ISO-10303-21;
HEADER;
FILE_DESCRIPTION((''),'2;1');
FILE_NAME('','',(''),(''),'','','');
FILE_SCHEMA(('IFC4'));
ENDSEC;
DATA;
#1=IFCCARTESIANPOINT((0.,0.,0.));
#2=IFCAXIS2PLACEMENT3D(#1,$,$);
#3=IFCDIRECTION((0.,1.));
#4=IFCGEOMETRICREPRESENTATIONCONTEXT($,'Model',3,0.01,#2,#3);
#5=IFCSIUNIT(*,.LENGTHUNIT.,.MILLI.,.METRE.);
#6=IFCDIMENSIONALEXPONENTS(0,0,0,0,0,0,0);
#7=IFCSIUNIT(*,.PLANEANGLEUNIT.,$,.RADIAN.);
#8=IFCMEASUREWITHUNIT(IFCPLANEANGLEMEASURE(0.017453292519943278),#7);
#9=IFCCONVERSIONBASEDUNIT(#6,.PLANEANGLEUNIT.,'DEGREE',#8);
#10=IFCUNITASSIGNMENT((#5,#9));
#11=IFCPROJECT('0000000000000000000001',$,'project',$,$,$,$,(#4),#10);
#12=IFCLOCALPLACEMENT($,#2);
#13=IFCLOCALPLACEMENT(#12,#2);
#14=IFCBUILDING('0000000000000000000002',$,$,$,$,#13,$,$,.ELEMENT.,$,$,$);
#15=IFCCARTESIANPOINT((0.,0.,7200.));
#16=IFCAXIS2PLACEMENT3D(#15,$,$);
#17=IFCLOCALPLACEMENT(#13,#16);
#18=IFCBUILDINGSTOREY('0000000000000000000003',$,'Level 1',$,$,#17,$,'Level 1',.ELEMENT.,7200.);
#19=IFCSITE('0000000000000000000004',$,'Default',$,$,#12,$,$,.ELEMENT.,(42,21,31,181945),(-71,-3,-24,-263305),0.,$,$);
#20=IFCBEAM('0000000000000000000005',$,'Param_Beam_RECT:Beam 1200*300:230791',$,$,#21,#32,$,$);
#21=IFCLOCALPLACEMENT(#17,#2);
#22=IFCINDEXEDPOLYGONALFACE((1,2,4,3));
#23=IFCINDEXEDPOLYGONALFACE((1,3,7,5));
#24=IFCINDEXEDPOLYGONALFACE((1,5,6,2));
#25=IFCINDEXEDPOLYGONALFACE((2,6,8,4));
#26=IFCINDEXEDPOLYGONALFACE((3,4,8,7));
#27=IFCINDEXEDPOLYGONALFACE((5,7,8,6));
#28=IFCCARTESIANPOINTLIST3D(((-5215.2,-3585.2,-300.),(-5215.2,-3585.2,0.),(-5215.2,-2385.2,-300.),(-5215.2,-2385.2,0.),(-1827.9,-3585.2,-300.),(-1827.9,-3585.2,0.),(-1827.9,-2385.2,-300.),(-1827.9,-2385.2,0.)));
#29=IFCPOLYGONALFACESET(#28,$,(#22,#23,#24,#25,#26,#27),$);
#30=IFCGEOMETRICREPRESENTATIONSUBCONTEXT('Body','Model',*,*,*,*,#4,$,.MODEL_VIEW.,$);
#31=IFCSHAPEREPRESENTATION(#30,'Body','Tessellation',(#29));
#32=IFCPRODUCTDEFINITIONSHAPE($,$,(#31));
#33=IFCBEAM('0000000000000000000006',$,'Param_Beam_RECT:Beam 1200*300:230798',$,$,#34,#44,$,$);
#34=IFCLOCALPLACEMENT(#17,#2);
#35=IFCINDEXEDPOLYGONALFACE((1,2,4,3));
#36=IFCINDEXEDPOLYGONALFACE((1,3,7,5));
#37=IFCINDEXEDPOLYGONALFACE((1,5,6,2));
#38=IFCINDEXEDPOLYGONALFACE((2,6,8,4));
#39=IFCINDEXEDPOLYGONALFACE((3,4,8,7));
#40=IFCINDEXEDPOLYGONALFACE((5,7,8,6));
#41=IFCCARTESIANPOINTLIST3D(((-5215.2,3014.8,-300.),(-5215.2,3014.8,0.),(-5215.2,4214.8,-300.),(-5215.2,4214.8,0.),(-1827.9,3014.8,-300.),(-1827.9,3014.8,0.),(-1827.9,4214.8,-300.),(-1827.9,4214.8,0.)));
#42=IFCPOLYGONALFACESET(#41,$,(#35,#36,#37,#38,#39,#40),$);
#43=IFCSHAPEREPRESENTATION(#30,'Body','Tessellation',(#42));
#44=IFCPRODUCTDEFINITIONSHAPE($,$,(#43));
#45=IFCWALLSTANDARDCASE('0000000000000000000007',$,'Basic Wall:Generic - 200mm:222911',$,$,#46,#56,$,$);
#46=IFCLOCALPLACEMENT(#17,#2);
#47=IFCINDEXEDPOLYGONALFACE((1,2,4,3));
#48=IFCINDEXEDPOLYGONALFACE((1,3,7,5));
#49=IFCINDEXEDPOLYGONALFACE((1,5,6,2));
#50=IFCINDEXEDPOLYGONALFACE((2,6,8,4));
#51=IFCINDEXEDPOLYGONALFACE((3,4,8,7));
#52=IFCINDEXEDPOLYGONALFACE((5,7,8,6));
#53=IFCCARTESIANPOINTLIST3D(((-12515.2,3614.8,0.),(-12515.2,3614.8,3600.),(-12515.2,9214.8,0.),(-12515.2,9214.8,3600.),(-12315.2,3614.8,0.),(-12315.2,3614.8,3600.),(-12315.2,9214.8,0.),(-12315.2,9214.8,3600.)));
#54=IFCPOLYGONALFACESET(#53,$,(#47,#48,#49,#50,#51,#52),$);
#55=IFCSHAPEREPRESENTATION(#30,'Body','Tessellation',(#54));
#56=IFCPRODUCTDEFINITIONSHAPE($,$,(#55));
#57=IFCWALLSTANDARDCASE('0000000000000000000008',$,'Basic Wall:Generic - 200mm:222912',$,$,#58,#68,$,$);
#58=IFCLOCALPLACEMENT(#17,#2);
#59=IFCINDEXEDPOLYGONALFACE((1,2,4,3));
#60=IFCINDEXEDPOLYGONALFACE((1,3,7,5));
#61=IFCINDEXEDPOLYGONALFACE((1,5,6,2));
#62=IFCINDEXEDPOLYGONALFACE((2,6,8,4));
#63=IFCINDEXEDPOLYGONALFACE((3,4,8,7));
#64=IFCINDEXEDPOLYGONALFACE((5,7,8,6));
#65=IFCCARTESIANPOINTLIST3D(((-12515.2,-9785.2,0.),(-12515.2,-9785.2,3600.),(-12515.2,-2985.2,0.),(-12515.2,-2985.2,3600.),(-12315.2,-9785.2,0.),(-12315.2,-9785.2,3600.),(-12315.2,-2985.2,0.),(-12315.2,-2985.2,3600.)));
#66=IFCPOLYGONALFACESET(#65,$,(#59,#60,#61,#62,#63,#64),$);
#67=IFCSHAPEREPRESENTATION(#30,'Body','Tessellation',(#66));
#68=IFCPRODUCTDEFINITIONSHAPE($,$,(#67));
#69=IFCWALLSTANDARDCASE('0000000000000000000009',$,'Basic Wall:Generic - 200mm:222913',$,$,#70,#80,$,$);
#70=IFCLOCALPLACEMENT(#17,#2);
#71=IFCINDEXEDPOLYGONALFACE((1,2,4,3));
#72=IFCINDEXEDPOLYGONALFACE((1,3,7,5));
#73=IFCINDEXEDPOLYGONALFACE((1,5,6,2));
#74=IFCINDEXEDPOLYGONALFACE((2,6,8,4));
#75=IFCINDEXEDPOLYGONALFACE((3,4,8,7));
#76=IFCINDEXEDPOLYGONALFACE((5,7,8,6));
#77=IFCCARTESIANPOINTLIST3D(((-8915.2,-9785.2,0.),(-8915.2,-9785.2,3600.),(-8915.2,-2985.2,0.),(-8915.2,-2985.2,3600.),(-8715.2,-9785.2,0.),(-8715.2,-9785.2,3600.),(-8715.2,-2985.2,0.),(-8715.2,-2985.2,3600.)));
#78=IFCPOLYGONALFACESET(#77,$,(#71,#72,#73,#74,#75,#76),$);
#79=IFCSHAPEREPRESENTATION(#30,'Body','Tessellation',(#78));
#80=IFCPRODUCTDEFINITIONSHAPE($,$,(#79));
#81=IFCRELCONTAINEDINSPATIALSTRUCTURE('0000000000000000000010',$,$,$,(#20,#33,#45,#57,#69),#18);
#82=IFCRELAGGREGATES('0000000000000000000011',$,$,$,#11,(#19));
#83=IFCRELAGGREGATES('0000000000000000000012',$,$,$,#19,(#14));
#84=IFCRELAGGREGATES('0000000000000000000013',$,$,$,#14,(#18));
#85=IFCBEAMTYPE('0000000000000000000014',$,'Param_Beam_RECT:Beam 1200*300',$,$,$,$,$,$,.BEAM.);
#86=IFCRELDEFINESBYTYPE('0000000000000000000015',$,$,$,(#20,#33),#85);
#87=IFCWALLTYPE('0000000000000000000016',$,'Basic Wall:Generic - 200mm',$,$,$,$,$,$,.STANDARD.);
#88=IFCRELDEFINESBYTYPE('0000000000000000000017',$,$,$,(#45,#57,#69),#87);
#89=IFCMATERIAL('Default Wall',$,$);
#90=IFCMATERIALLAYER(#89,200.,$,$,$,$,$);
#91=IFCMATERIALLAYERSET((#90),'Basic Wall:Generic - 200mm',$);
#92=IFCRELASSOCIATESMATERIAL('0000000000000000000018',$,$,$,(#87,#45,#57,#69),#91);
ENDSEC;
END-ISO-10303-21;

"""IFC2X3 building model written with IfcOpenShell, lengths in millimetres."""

from ifc_helpers import new_model, entity, si_unit, converted_unit, direction, frame, frame_2d, origin, place, context, subcontext, project, spatial, rectangle, extrude, material, layer, layer_set, layer_usage, type_object, element, save


model = new_model("IFC2X3")

# Units and contexts
model_context = context("Model", 3, precision=0.01, world=origin(), true_north=direction((0.0, 1.0)))
body_context = subcontext(model_context, "Body", "Model", "MODEL_VIEW")
ifc_project = project(units=[si_unit("LENGTHUNIT", "METRE", prefix="MILLI"), converted_unit("PLANEANGLEUNIT", "DEGREE", entity("IfcPlaneAngleMeasure", 0.017453292519943278), si_unit("PLANEANGLEUNIT", "RADIAN"), dimensions=[0, 0, 0, 0, 0, 0, 0])], contexts=[model_context])

# Site, building, storey
site_placement = place(None, origin())
site = spatial("IfcSite", under=ifc_project, at=site_placement, Name="Default", CompositionType="ELEMENT", RefLatitude=(42, 21, 31, 181945), RefLongitude=(-71, -3, -24, -263305), RefElevation=0.0)
building_placement = place(site_placement, origin())
building = spatial("IfcBuilding", under=site, at=building_placement, CompositionType="ELEMENT")
storey_placement = place(building_placement, frame((0.0, 0.0, 7200.0)))
storey = spatial("IfcBuildingStorey", under=building, at=storey_placement, Name="Level 1", LongName="Level 1", CompositionType="ELEMENT", Elevation=7200.0)

# Beams
beam_type_1 = type_object("IfcBeamType", Name="Param_Beam_RECT:Beam 1200*300", PredefinedType="BEAM")
beam_1_placement = place(storey_placement, frame((-5215.2, -2985.2, 0.0)))
element("IfcBeam", 1, at=beam_1_placement, inside=storey, type_object=beam_type_1, Name="Param_Beam_RECT:Beam 1200*300:230791", context=body_context, shape_type="SweptSolid", body=[
    extrude(rectangle(XDim=300.0, YDim=1200.0, at=frame_2d((0.0, 0.0), x_axis=(1.0, 0.0))), frame((0.0, 0.0, -150.0), z_axis=(1.0, 0.0, 0.0), x_axis=(0.0, 0.0, -1.0)), (0.0, 0.0, 1.0), 3387.3),
])
beam_2_placement = place(storey_placement, frame((-5215.2, 3614.8, 0.0)))
element("IfcBeam", 2, at=beam_2_placement, inside=storey, type_object=beam_type_1, Name="Param_Beam_RECT:Beam 1200*300:230798", context=body_context, shape_type="SweptSolid", body=[
    extrude(rectangle(XDim=300.0, YDim=1200.0, at=frame_2d((0.0, 0.0), x_axis=(1.0, 0.0))), frame((0.0, 0.0, -150.0), z_axis=(1.0, 0.0, 0.0), x_axis=(0.0, 0.0, -1.0)), (0.0, 0.0, 1.0), 3387.3),
])

# Walls
ifc_material_1 = material(Name="Default Wall")
ifc_layer = layer(ifc_material_1, 200.0)
ifc_layer_set = layer_set([ifc_layer], Name="Basic Wall:Generic - 200mm")
ifc_layer_usage_1 = layer_usage(ifc_layer_set, "AXIS2", "NEGATIVE", 100.0)
wall_type = type_object("IfcWallType", Name="Basic Wall:Generic - 200mm", PredefinedType="STANDARD", material=ifc_layer_set)
wall_1_placement = place(storey_placement, frame((-12415.2, 3614.8, 0.0), z_axis=(0.0, 0.0, 1.0), x_axis=(0.0, 1.0, 0.0)))
element("IfcWallStandardCase", 3, at=wall_1_placement, inside=storey, type_object=wall_type, material=ifc_layer_usage_1, Name="Basic Wall:Generic - 200mm:222911", context=body_context, shape_type="SweptSolid", body=[
    extrude(rectangle(XDim=5600.0, YDim=200.0, at=frame_2d((2800.0, 0.0), x_axis=(-1.0, 0.0))), origin(), (0.0, 0.0, 1.0), 3600.0),
])
ifc_layer_usage_2 = layer_usage(ifc_layer_set, "AXIS2", "NEGATIVE", 100.0)
wall_2_placement = place(storey_placement, frame((-12415.2, -9785.2, 0.0), z_axis=(0.0, 0.0, 1.0), x_axis=(0.0, 1.0, 0.0)))
element("IfcWallStandardCase", 4, at=wall_2_placement, inside=storey, type_object=wall_type, material=ifc_layer_usage_2, Name="Basic Wall:Generic - 200mm:222912", context=body_context, shape_type="SweptSolid", body=[
    extrude(rectangle(XDim=6800.0, YDim=200.0, at=frame_2d((3400.0, 0.0), x_axis=(-1.0, 0.0))), origin(), (0.0, 0.0, 1.0), 3600.0),
])
ifc_layer_usage_3 = layer_usage(ifc_layer_set, "AXIS2", "NEGATIVE", 100.0)
wall_3_placement = place(storey_placement, frame((-8815.2, -9785.2, 0.0), z_axis=(0.0, 0.0, 1.0), x_axis=(0.0, 1.0, 0.0)))
element("IfcWallStandardCase", 5, at=wall_3_placement, inside=storey, type_object=wall_type, material=ifc_layer_usage_3, Name="Basic Wall:Generic - 200mm:222913", context=body_context, shape_type="SweptSolid", body=[
    extrude(rectangle(XDim=6800.0, YDim=200.0, at=frame_2d((3400.0, 0.0), x_axis=(-1.0, 0.0))), origin(), (0.0, 0.0, 1.0), 3600.0),
])

save(model, "model.ifc")
